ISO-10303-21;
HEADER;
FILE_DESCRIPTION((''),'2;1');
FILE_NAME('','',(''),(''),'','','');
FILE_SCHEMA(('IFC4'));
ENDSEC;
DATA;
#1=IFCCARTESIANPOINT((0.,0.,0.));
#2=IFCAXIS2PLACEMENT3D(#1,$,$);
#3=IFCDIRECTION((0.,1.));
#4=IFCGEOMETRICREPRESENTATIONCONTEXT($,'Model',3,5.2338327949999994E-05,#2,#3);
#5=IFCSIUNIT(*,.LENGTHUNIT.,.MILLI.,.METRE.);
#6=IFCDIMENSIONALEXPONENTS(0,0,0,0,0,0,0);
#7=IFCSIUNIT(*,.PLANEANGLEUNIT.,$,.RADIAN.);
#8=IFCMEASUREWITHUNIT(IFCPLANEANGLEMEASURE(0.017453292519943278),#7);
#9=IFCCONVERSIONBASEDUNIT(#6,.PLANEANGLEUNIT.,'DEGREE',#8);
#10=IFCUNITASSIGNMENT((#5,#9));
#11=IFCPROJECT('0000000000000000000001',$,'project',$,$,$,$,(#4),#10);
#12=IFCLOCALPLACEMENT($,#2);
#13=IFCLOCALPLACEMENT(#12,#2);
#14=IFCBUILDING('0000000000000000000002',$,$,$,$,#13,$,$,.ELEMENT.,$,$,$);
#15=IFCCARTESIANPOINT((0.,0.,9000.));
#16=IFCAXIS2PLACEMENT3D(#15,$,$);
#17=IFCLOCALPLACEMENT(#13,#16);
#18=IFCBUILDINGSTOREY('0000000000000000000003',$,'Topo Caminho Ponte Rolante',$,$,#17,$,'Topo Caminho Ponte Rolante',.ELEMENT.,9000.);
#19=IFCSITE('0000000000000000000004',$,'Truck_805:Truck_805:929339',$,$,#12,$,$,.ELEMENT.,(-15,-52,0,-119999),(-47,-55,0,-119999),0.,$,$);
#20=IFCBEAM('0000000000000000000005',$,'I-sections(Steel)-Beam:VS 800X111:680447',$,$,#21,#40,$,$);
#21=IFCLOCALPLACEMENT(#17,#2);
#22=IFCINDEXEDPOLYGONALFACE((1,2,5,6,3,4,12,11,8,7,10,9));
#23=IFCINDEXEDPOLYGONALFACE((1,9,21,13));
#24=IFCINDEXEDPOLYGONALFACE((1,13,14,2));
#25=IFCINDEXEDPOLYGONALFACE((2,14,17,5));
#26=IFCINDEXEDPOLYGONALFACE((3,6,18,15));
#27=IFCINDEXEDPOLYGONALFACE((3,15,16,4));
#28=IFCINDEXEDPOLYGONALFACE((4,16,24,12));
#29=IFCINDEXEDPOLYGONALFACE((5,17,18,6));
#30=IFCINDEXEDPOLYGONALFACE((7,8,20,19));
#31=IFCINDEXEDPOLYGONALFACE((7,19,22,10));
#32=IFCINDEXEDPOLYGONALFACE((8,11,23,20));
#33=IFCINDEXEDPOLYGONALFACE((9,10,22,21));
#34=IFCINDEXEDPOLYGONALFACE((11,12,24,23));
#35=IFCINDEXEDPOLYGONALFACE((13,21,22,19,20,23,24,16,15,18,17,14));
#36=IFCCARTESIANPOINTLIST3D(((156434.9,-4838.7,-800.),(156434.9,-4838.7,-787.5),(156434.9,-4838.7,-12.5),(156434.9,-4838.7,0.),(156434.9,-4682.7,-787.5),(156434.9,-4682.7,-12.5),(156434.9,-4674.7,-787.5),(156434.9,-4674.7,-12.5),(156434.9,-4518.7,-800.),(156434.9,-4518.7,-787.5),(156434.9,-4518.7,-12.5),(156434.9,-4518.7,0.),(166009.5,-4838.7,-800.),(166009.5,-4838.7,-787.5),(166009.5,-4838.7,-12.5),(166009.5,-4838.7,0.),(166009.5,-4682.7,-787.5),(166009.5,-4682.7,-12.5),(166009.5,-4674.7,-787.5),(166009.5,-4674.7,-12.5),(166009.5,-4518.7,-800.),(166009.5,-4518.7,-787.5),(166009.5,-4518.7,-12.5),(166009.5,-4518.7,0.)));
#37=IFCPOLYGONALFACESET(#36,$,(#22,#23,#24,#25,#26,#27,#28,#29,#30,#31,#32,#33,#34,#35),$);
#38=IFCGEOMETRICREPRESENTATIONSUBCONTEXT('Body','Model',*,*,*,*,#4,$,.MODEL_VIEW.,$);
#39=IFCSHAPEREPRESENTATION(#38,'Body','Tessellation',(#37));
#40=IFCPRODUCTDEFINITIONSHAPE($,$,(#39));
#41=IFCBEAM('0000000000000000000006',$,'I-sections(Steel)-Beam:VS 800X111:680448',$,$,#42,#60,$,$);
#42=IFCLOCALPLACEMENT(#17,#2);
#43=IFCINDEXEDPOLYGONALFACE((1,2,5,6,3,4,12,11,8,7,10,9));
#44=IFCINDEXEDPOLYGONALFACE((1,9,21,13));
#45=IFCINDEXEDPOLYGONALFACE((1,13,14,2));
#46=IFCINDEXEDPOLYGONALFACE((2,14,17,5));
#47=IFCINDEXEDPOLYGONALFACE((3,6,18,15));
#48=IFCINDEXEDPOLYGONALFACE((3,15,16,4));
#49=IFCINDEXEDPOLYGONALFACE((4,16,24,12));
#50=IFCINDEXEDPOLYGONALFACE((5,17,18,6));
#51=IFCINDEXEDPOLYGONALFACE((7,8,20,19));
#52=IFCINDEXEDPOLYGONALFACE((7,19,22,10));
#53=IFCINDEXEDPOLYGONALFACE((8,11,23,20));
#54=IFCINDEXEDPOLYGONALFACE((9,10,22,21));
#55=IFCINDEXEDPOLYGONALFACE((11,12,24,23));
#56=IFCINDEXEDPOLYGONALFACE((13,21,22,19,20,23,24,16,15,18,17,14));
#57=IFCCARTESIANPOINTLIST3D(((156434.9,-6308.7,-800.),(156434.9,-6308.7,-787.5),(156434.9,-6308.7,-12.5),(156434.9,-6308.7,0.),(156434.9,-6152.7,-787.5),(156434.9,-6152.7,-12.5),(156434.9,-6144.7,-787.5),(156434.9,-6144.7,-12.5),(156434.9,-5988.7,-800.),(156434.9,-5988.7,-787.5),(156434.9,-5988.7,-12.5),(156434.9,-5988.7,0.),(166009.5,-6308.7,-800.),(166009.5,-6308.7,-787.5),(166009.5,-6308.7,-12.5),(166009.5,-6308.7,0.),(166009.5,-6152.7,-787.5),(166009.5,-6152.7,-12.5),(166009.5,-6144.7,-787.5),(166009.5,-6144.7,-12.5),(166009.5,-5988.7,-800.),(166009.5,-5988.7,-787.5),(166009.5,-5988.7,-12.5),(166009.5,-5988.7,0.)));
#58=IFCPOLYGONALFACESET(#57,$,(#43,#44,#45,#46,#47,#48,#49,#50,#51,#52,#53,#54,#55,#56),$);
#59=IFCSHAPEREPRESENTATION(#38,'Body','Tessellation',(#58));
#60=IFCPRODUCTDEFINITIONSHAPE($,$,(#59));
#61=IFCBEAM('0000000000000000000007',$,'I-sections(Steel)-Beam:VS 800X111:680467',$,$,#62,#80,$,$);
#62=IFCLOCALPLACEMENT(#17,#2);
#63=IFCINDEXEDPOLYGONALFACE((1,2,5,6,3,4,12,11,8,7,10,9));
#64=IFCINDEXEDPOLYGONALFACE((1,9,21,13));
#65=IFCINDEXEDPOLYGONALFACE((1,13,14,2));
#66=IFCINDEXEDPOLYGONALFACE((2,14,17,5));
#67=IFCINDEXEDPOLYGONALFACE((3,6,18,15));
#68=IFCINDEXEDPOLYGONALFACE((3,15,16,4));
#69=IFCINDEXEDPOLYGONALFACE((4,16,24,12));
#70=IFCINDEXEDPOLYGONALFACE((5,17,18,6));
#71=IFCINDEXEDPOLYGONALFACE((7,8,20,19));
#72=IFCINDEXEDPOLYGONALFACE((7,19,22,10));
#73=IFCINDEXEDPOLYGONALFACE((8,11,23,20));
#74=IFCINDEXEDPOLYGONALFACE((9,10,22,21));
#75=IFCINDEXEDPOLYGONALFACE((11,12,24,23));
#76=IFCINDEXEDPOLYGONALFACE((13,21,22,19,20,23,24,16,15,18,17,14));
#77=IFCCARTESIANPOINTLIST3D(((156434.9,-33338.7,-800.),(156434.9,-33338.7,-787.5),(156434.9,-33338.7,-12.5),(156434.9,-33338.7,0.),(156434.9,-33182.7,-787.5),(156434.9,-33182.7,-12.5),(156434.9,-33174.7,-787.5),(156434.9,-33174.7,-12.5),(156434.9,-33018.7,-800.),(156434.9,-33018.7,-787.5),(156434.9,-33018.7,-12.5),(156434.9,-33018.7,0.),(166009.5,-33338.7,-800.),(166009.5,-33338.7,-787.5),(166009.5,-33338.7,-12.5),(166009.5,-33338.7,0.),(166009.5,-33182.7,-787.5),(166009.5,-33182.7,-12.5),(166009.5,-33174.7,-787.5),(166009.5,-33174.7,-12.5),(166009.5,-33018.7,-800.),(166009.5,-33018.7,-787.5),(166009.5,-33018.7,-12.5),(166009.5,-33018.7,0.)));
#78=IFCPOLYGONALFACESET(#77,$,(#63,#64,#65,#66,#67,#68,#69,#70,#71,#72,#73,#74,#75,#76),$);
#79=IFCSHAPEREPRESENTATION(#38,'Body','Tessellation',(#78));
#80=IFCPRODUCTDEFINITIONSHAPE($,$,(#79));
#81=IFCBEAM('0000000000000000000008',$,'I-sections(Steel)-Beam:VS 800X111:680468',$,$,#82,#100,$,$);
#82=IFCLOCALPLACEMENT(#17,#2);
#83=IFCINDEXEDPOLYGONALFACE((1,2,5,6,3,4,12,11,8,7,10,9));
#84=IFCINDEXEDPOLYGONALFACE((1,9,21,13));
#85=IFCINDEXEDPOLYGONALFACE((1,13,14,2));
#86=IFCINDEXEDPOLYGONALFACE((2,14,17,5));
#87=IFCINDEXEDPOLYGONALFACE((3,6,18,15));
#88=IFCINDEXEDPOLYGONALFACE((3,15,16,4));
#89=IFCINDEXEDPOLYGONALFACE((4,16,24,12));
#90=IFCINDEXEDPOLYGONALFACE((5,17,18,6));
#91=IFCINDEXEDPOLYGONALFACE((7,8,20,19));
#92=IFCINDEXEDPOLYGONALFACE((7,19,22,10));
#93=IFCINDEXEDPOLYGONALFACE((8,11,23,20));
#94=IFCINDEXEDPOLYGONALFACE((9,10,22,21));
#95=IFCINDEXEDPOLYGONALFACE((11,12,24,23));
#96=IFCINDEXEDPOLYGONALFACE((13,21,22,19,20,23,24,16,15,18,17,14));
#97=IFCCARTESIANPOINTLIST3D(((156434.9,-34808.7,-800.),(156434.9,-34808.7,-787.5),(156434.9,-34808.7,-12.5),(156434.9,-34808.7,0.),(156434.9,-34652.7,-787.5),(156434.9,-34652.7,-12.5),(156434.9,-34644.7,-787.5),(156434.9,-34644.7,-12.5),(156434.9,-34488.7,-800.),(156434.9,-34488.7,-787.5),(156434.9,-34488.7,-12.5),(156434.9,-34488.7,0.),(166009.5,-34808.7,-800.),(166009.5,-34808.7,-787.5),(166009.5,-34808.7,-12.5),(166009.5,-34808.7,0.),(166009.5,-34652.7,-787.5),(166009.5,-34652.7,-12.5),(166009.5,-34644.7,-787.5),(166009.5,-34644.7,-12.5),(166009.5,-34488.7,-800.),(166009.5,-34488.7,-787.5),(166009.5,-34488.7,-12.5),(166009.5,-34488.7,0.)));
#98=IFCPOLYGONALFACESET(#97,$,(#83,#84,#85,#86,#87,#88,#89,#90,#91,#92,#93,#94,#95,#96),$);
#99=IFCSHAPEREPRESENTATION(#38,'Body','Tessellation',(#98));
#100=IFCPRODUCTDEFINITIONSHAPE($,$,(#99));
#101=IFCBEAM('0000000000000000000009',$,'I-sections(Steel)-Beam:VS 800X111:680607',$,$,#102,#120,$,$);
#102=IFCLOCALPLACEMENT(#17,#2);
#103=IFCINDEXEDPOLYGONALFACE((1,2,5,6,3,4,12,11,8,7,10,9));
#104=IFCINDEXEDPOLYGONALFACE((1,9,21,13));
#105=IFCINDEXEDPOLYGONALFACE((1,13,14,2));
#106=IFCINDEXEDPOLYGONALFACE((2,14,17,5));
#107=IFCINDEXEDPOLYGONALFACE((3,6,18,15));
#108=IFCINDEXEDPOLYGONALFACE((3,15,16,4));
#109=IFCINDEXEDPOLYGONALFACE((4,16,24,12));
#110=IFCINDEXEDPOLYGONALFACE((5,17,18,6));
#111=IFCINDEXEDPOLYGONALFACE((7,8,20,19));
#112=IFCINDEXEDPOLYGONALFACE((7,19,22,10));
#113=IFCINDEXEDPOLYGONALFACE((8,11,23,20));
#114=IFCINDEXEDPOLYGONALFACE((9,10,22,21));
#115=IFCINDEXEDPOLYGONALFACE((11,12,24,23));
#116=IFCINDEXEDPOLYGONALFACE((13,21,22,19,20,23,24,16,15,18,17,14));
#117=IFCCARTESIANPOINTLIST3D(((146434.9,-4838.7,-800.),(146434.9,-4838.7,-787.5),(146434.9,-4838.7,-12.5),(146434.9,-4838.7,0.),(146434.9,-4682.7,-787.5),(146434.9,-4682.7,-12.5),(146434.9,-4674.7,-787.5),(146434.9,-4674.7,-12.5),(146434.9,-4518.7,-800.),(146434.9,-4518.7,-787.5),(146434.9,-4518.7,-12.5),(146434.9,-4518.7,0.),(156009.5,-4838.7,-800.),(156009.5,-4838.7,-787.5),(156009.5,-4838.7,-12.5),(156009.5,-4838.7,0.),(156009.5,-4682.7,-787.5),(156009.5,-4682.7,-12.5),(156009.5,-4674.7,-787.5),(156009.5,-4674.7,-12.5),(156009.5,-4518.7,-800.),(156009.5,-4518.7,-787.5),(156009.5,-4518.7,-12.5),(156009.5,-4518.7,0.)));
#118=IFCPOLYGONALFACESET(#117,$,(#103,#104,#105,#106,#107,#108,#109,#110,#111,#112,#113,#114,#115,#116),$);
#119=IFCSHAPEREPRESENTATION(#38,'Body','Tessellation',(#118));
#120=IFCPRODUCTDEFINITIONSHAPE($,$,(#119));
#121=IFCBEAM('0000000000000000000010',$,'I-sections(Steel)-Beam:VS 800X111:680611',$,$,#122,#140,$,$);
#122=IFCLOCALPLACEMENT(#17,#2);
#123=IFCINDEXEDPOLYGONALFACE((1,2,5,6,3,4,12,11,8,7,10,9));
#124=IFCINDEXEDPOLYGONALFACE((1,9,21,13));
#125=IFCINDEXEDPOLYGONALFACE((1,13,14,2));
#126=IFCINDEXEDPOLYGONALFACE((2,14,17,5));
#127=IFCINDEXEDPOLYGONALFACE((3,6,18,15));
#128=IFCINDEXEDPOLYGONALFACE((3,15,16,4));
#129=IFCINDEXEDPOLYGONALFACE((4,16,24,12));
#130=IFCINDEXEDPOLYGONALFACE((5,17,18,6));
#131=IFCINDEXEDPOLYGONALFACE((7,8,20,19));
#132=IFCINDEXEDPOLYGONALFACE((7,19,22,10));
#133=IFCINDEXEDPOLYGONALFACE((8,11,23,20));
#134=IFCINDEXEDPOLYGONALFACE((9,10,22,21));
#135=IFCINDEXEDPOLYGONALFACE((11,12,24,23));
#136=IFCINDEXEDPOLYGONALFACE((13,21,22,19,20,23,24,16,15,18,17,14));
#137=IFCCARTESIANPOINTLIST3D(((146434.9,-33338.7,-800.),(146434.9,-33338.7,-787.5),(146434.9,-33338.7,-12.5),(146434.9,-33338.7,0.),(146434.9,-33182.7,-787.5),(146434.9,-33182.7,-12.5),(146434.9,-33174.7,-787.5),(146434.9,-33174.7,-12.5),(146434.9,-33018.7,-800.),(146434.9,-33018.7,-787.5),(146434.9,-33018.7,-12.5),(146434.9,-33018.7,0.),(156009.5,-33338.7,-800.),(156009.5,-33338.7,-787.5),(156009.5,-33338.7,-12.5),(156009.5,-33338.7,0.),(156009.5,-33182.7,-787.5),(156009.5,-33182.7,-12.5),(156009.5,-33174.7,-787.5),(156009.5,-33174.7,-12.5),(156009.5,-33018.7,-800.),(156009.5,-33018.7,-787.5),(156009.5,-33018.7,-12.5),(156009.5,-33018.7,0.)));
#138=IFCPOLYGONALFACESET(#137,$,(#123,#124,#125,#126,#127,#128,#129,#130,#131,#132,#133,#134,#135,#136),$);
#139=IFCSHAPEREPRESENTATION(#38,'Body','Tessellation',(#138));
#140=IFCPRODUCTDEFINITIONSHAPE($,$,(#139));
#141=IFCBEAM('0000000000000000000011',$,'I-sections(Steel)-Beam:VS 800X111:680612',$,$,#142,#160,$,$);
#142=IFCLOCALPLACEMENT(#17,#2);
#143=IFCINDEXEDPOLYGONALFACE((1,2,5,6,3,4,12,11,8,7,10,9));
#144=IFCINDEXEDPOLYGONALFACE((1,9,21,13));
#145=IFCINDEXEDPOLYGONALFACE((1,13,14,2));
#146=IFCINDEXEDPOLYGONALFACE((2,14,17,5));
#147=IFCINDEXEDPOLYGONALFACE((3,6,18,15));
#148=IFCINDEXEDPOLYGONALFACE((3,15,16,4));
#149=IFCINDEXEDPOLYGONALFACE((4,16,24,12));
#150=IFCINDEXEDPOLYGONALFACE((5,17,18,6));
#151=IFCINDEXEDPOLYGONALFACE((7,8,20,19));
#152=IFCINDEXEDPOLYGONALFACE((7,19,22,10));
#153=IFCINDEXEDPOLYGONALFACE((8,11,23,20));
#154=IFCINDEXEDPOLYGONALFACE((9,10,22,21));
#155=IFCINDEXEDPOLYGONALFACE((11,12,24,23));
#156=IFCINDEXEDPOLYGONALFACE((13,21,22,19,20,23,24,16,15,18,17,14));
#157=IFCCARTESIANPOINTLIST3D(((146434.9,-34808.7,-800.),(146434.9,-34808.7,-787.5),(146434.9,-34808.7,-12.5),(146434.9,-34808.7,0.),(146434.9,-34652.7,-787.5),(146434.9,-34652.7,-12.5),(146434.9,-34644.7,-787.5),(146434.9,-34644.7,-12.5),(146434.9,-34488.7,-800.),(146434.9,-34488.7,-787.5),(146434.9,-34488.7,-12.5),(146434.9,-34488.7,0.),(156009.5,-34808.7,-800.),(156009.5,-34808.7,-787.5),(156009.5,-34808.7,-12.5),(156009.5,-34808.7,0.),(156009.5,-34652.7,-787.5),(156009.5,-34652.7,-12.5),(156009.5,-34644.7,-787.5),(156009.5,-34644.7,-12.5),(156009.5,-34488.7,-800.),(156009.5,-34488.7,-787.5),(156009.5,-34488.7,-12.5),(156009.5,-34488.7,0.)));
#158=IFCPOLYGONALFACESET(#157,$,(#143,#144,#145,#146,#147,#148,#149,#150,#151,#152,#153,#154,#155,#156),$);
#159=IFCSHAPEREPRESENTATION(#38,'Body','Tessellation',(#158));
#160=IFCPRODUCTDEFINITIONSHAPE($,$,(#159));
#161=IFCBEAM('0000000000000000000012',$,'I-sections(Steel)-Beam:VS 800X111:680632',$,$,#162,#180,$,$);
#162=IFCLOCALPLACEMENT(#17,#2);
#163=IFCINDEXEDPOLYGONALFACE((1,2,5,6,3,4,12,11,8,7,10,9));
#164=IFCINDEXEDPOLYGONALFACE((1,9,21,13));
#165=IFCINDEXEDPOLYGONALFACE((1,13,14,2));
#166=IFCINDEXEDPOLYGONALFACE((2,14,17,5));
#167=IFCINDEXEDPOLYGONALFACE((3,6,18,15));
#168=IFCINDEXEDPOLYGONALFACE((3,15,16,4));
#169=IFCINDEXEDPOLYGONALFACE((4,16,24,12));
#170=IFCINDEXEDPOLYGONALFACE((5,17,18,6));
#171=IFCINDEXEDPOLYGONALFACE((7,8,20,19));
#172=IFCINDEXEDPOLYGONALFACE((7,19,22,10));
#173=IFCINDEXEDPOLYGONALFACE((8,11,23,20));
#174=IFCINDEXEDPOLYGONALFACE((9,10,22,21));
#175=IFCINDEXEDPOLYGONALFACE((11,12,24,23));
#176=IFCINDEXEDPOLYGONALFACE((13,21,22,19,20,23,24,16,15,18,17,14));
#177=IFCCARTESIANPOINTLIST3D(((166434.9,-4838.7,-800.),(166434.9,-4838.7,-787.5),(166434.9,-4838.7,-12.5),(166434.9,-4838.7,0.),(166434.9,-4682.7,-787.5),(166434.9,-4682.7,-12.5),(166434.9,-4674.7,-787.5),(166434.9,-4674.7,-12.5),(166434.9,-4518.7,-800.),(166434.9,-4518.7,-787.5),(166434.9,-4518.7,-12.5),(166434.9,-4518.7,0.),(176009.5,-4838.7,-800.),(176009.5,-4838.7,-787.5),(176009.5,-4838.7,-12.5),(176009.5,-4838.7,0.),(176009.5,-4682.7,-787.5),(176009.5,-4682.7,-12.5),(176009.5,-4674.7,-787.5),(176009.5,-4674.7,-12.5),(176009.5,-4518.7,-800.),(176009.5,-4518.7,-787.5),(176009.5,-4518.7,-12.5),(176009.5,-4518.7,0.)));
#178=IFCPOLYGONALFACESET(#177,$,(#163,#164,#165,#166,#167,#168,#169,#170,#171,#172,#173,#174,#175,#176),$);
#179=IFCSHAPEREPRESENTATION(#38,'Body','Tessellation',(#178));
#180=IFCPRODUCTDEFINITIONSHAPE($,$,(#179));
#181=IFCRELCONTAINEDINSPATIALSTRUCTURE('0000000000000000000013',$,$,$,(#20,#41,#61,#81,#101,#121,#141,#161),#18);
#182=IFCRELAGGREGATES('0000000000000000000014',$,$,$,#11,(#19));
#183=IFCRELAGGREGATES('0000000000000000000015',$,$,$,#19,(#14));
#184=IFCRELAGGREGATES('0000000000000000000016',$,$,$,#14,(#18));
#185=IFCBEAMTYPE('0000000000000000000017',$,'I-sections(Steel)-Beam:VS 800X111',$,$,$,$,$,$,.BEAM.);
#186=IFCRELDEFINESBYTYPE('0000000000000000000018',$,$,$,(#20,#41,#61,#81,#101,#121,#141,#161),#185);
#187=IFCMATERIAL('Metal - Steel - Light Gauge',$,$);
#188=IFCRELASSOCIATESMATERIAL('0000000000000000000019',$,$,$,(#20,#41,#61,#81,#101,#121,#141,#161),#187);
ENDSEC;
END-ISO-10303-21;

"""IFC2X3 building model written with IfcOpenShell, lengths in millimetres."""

from ifc_helpers import new_model, entity, si_unit, converted_unit, direction, frame, frame_2d, origin, place, context, subcontext, project, spatial, polyline, i_section, outline, extrude, material, type_object, element, save


model = new_model("IFC2X3")

# Units and contexts
model_context = context("Model", 3, precision=5.2338327949999994e-05, world=origin(), true_north=direction((0.0, 1.0)))
body_context = subcontext(model_context, "Body", "Model", "MODEL_VIEW")
ifc_project = project(units=[si_unit("LENGTHUNIT", "METRE", prefix="MILLI"), converted_unit("PLANEANGLEUNIT", "DEGREE", entity("IfcPlaneAngleMeasure", 0.017453292519943278), si_unit("PLANEANGLEUNIT", "RADIAN"), dimensions=[0, 0, 0, 0, 0, 0, 0])], contexts=[model_context])

# Site, building, storey
site_placement = place(None, origin())
site = spatial("IfcSite", under=ifc_project, at=site_placement, Name="Truck_805:Truck_805:929339", CompositionType="ELEMENT", RefLatitude=(-15, -52, 0, -119999), RefLongitude=(-47, -55, 0, -119999), RefElevation=0.0)
building_placement = place(site_placement, origin())
building = spatial("IfcBuilding", under=site, at=building_placement, CompositionType="ELEMENT")
storey_placement = place(building_placement, frame((0.0, 0.0, 9000.0)))
storey = spatial("IfcBuildingStorey", under=building, at=storey_placement, Name="Topo Caminho Ponte Rolante", LongName="Topo Caminho Ponte Rolante", CompositionType="ELEMENT", Elevation=9000.0)

# Beams
ifc_material = material(Name="Metal - Steel - Light Gauge")
beam_type_1 = type_object("IfcBeamType", Name="I-sections(Steel)-Beam:VS 800X111", PredefinedType="BEAM")
beam_1_placement = place(storey_placement, frame((156222.2, -4678.7, 0.0)))
element("IfcBeam", 1, at=beam_1_placement, inside=storey, type_object=beam_type_1, material=ifc_material, Name="I-sections(Steel)-Beam:VS 800X111:680447", context=body_context, shape_type="SweptSolid", body=[
    extrude(i_section(OverallWidth=320.0, OverallDepth=800.0, WebThickness=8.0, FlangeThickness=12.5, at=frame_2d((0.0, 0.0), x_axis=(0.0, 1.0))), frame((212.7, 0.0, -400.0), z_axis=(1.0, 0.0, 0.0), x_axis=(0.0, 0.0, -1.0)), (0.0, 0.0, 1.0), 9574.6),
])
beam_2_placement = place(storey_placement, frame((156206.9, -6148.7, 0.0)))
element("IfcBeam", 2, at=beam_2_placement, inside=storey, type_object=beam_type_1, material=ifc_material, Name="I-sections(Steel)-Beam:VS 800X111:680448", context=body_context, shape_type="SweptSolid", body=[
    extrude(outline(polyline([(387.5, -160.0), (400.0, -160.0), (400.0, 160.0), (387.5, 160.0), (387.5, 4.0), (-387.5, 4.0), (-387.5, 160.0), (-400.0, 160.0), (-400.0, -160.0), (-387.5, -160.0), (-387.5, -4.0), (387.5, -4.0), (387.5, -160.0)])), frame((227.9, 0.0, -400.0), z_axis=(1.0, 0.0, 0.0), x_axis=(0.0, 0.0, -1.0)), (0.0, 0.0, 1.0), 9574.6),
])
beam_3_placement = place(storey_placement, frame((156222.2, -33178.7, 0.0)))
element("IfcBeam", 3, at=beam_3_placement, inside=storey, type_object=beam_type_1, material=ifc_material, Name="I-sections(Steel)-Beam:VS 800X111:680467", context=body_context, shape_type="SweptSolid", body=[
    extrude(i_section(OverallWidth=320.0, OverallDepth=800.0, WebThickness=8.0, FlangeThickness=12.5, at=frame_2d((0.0, 0.0), x_axis=(0.0, 1.0))), frame((212.7, 0.0, -400.0), z_axis=(1.0, 0.0, 0.0), x_axis=(0.0, 0.0, -1.0)), (0.0, 0.0, 1.0), 9574.6),
])
beam_4_placement = place(storey_placement, frame((156222.2, -34648.7, 0.0)))
element("IfcBeam", 4, at=beam_4_placement, inside=storey, type_object=beam_type_1, material=ifc_material, Name="I-sections(Steel)-Beam:VS 800X111:680468", context=body_context, shape_type="SweptSolid", body=[
    extrude(outline(polyline([(387.5, -160.0), (400.0, -160.0), (400.0, 160.0), (387.5, 160.0), (387.5, 4.0), (-387.5, 4.0), (-387.5, 160.0), (-400.0, 160.0), (-400.0, -160.0), (-387.5, -160.0), (-387.5, -4.0), (387.5, -4.0), (387.5, -160.0)])), frame((212.7, 0.0, -400.0), z_axis=(1.0, 0.0, 0.0), x_axis=(0.0, 0.0, -1.0)), (0.0, 0.0, 1.0), 9574.6),
])
beam_5_placement = place(storey_placement, frame((146222.2, -4678.7, 0.0)))
element("IfcBeam", 5, at=beam_5_placement, inside=storey, type_object=beam_type_1, material=ifc_material, Name="I-sections(Steel)-Beam:VS 800X111:680607", context=body_context, shape_type="SweptSolid", body=[
    extrude(i_section(OverallWidth=320.0, OverallDepth=800.0, WebThickness=8.0, FlangeThickness=12.5, at=frame_2d((0.0, 0.0), x_axis=(0.0, 1.0))), frame((212.7, 0.0, -400.0), z_axis=(1.0, 0.0, 0.0), x_axis=(0.0, 0.0, -1.0)), (0.0, 0.0, 1.0), 9574.6),
])
beam_6_placement = place(storey_placement, frame((146222.2, -33178.7, 0.0)))
element("IfcBeam", 6, at=beam_6_placement, inside=storey, type_object=beam_type_1, material=ifc_material, Name="I-sections(Steel)-Beam:VS 800X111:680611", context=body_context, shape_type="SweptSolid", body=[
    extrude(i_section(OverallWidth=320.0, OverallDepth=800.0, WebThickness=8.0, FlangeThickness=12.5, at=frame_2d((0.0, 0.0), x_axis=(0.0, 1.0))), frame((212.7, 0.0, -400.0), z_axis=(1.0, 0.0, 0.0), x_axis=(0.0, 0.0, -1.0)), (0.0, 0.0, 1.0), 9574.6),
])
beam_7_placement = place(storey_placement, frame((146222.2, -34648.7, 0.0)))
element("IfcBeam", 7, at=beam_7_placement, inside=storey, type_object=beam_type_1, material=ifc_material, Name="I-sections(Steel)-Beam:VS 800X111:680612", context=body_context, shape_type="SweptSolid", body=[
    extrude(outline(polyline([(387.5, -160.0), (400.0, -160.0), (400.0, 160.0), (387.5, 160.0), (387.5, 4.0), (-387.5, 4.0), (-387.5, 160.0), (-400.0, 160.0), (-400.0, -160.0), (-387.5, -160.0), (-387.5, -4.0), (387.5, -4.0), (387.5, -160.0)])), frame((212.7, 0.0, -400.0), z_axis=(1.0, 0.0, 0.0), x_axis=(0.0, 0.0, -1.0)), (0.0, 0.0, 1.0), 9574.6),
])
beam_8_placement = place(storey_placement, frame((166222.2, -4678.7, 0.0)))
element("IfcBeam", 8, at=beam_8_placement, inside=storey, type_object=beam_type_1, material=ifc_material, Name="I-sections(Steel)-Beam:VS 800X111:680632", context=body_context, shape_type="SweptSolid", body=[
    extrude(i_section(OverallWidth=320.0, OverallDepth=800.0, WebThickness=8.0, FlangeThickness=12.5, at=frame_2d((0.0, 0.0), x_axis=(0.0, 1.0))), frame((212.7, 0.0, -400.0), z_axis=(1.0, 0.0, 0.0), x_axis=(0.0, 0.0, -1.0)), (0.0, 0.0, 1.0), 9574.6),
])

save(model, "model.ifc")
